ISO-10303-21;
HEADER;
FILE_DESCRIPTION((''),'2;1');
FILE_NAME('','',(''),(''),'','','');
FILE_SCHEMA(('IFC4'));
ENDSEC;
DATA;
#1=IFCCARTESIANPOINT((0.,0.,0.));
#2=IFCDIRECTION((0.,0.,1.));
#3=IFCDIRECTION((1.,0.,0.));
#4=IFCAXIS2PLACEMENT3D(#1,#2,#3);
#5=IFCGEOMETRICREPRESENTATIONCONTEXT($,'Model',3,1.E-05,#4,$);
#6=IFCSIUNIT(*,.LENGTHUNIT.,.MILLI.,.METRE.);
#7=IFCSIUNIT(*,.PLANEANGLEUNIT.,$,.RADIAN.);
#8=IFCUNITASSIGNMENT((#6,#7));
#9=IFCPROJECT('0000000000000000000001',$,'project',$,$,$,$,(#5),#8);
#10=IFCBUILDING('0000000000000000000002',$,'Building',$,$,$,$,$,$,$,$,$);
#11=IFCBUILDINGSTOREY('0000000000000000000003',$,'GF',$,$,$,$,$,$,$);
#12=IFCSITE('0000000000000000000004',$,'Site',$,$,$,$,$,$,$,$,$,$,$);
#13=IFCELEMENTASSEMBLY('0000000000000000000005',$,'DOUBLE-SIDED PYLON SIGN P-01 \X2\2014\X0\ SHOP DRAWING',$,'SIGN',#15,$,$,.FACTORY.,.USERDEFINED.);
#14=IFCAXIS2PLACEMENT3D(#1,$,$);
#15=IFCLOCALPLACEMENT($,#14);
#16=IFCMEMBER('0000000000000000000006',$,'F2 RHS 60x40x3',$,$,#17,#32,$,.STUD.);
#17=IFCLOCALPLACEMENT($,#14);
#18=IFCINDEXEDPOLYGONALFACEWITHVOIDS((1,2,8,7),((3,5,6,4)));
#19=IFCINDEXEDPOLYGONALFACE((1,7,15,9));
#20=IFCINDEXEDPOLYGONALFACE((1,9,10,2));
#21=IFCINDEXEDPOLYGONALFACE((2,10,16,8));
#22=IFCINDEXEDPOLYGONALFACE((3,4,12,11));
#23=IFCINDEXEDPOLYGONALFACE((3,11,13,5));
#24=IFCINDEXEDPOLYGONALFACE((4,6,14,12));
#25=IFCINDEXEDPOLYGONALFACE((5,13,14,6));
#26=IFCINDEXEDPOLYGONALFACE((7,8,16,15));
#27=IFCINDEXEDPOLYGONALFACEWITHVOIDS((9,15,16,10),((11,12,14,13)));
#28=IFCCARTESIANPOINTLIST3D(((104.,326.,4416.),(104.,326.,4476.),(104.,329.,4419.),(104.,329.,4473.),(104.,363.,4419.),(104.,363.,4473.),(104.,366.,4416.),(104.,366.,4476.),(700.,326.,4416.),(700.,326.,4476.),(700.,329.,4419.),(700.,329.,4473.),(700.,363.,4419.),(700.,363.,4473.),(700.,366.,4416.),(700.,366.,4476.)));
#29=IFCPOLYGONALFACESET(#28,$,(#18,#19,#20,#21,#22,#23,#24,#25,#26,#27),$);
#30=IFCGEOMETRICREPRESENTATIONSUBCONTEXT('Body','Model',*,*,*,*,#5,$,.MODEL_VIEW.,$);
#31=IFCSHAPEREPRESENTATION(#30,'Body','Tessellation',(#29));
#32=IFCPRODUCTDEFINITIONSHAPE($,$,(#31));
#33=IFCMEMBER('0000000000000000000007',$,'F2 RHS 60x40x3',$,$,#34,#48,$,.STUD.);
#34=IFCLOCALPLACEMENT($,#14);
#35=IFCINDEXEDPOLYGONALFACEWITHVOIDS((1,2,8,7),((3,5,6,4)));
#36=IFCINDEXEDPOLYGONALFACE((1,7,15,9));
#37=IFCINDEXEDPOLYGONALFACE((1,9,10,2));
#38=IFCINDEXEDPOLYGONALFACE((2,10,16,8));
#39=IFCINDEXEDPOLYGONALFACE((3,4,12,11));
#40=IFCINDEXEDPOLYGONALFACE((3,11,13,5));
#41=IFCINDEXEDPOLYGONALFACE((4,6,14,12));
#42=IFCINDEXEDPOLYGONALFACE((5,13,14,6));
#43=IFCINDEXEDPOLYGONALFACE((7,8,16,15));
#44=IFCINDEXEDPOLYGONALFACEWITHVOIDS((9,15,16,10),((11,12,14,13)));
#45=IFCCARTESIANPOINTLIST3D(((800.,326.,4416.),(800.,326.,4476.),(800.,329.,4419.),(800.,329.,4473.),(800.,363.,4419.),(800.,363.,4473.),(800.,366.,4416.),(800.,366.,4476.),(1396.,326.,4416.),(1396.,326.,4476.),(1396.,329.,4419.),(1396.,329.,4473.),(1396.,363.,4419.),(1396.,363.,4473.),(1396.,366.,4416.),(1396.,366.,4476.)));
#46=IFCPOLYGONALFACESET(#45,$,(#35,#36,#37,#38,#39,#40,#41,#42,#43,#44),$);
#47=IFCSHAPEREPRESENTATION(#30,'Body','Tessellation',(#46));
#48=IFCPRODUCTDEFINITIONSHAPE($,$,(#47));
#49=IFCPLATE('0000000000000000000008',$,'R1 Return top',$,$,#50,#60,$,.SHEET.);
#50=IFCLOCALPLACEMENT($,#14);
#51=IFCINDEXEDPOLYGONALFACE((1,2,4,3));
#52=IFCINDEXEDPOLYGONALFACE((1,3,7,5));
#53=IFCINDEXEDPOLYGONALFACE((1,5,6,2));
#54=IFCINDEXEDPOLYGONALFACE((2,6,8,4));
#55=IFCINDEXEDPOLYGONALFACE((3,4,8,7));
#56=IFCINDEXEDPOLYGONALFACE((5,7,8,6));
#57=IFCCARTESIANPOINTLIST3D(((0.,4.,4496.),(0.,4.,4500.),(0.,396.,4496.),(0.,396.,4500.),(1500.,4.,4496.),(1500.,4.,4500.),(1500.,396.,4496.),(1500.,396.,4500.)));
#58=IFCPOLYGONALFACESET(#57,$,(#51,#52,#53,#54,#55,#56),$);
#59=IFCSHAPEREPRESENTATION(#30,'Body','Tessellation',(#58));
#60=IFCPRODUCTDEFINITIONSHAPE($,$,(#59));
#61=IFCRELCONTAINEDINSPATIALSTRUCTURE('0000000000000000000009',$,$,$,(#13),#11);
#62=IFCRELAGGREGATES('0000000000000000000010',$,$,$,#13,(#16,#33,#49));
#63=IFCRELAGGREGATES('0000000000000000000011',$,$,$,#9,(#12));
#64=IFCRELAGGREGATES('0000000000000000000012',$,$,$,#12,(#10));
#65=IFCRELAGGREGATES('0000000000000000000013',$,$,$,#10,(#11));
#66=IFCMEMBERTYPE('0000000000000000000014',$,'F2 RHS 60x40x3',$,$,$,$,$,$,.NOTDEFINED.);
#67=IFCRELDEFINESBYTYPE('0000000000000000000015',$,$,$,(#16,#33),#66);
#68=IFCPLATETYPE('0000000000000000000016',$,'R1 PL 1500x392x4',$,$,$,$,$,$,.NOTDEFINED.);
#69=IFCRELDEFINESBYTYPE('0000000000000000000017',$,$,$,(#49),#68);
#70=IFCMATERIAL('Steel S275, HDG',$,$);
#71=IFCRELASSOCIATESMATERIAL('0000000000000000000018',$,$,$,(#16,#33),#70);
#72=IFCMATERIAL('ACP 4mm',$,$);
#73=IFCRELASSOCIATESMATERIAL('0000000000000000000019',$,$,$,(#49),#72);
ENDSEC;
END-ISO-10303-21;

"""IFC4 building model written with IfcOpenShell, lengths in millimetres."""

from ifc_helpers import new_model, si_unit, frame, frame_2d, origin, origin_with_axes, place, context, subcontext, project, spatial, rectangle, hollow_rectangle, extrude, material, type_object, element, aggregate, save


model = new_model("IFC4")

# Units and contexts
model_context = context("Model", 3, precision=1e-05, world=origin_with_axes())
body_context = subcontext(model_context, "Body", "Model", "MODEL_VIEW")
ifc_project = project(units=[si_unit("LENGTHUNIT", "METRE", prefix="MILLI"), si_unit("PLANEANGLEUNIT", "RADIAN")], contexts=[model_context])

# Site, building, storey
site = spatial("IfcSite", under=ifc_project, Name="Site")
building = spatial("IfcBuilding", under=site, Name="Building")
storey = spatial("IfcBuildingStorey", under=building, Name="GF")

# Element assembly, members, plate
assembly_placement = place(None, origin_with_axes())
assembly = element("IfcElementAssembly", 1, at=assembly_placement, inside=storey, Name="DOUBLE-SIDED PYLON SIGN P-01 — SHOP DRAWING", ObjectType="SIGN", AssemblyPlace="FACTORY", PredefinedType="USERDEFINED")
ifc_material_1 = material(Name="Steel S275, HDG")
member_type = type_object("IfcMemberType", Name="F2 RHS 60x40x3", PredefinedType="NOTDEFINED")
member_1_placement = place(assembly_placement, frame((104.0, 346.0, 4446.0), z_axis=(1.0, 0.0, 0.0), x_axis=(0.0, 0.0, 1.0)))
member_1 = element("IfcMember", 2, at=member_1_placement, type_object=member_type, material=ifc_material_1, Name="F2 RHS 60x40x3", PredefinedType="STUD", context=body_context, shape_type="SweptSolid", body=[
    extrude(hollow_rectangle(XDim=60.0, YDim=40.0, WallThickness=3.0), origin(), (0.0, 0.0, 1.0), 596.0),
])
member_2_placement = place(assembly_placement, frame((800.0, 346.0, 4446.0), z_axis=(1.0, 0.0, 0.0), x_axis=(0.0, 0.0, 1.0)))
member_2 = element("IfcMember", 3, at=member_2_placement, type_object=member_type, material=ifc_material_1, Name="F2 RHS 60x40x3", PredefinedType="STUD", context=body_context, shape_type="SweptSolid", body=[
    extrude(hollow_rectangle(XDim=60.0, YDim=40.0, WallThickness=3.0), origin(), (0.0, 0.0, 1.0), 596.0),
])
ifc_material_2 = material(Name="ACP 4mm")
plate_type = type_object("IfcPlateType", Name="R1 PL 1500x392x4", PredefinedType="NOTDEFINED")
plate_placement = place(assembly_placement, frame((0.0, 4.0, 4496.0), z_axis=(0.0, 0.0, 1.0), x_axis=(1.0, 0.0, 0.0)))
plate = element("IfcPlate", 4, at=plate_placement, type_object=plate_type, material=ifc_material_2, Name="R1 Return top", PredefinedType="SHEET", context=body_context, shape_type="SweptSolid", body=[
    extrude(rectangle(XDim=1500.0, YDim=392.0, at=frame_2d((750.0, 196.0))), origin(), (0.0, 0.0, 1.0), 4.0),
])
aggregate(assembly, [member_1, member_2, plate])

save(model, "model.ifc")
